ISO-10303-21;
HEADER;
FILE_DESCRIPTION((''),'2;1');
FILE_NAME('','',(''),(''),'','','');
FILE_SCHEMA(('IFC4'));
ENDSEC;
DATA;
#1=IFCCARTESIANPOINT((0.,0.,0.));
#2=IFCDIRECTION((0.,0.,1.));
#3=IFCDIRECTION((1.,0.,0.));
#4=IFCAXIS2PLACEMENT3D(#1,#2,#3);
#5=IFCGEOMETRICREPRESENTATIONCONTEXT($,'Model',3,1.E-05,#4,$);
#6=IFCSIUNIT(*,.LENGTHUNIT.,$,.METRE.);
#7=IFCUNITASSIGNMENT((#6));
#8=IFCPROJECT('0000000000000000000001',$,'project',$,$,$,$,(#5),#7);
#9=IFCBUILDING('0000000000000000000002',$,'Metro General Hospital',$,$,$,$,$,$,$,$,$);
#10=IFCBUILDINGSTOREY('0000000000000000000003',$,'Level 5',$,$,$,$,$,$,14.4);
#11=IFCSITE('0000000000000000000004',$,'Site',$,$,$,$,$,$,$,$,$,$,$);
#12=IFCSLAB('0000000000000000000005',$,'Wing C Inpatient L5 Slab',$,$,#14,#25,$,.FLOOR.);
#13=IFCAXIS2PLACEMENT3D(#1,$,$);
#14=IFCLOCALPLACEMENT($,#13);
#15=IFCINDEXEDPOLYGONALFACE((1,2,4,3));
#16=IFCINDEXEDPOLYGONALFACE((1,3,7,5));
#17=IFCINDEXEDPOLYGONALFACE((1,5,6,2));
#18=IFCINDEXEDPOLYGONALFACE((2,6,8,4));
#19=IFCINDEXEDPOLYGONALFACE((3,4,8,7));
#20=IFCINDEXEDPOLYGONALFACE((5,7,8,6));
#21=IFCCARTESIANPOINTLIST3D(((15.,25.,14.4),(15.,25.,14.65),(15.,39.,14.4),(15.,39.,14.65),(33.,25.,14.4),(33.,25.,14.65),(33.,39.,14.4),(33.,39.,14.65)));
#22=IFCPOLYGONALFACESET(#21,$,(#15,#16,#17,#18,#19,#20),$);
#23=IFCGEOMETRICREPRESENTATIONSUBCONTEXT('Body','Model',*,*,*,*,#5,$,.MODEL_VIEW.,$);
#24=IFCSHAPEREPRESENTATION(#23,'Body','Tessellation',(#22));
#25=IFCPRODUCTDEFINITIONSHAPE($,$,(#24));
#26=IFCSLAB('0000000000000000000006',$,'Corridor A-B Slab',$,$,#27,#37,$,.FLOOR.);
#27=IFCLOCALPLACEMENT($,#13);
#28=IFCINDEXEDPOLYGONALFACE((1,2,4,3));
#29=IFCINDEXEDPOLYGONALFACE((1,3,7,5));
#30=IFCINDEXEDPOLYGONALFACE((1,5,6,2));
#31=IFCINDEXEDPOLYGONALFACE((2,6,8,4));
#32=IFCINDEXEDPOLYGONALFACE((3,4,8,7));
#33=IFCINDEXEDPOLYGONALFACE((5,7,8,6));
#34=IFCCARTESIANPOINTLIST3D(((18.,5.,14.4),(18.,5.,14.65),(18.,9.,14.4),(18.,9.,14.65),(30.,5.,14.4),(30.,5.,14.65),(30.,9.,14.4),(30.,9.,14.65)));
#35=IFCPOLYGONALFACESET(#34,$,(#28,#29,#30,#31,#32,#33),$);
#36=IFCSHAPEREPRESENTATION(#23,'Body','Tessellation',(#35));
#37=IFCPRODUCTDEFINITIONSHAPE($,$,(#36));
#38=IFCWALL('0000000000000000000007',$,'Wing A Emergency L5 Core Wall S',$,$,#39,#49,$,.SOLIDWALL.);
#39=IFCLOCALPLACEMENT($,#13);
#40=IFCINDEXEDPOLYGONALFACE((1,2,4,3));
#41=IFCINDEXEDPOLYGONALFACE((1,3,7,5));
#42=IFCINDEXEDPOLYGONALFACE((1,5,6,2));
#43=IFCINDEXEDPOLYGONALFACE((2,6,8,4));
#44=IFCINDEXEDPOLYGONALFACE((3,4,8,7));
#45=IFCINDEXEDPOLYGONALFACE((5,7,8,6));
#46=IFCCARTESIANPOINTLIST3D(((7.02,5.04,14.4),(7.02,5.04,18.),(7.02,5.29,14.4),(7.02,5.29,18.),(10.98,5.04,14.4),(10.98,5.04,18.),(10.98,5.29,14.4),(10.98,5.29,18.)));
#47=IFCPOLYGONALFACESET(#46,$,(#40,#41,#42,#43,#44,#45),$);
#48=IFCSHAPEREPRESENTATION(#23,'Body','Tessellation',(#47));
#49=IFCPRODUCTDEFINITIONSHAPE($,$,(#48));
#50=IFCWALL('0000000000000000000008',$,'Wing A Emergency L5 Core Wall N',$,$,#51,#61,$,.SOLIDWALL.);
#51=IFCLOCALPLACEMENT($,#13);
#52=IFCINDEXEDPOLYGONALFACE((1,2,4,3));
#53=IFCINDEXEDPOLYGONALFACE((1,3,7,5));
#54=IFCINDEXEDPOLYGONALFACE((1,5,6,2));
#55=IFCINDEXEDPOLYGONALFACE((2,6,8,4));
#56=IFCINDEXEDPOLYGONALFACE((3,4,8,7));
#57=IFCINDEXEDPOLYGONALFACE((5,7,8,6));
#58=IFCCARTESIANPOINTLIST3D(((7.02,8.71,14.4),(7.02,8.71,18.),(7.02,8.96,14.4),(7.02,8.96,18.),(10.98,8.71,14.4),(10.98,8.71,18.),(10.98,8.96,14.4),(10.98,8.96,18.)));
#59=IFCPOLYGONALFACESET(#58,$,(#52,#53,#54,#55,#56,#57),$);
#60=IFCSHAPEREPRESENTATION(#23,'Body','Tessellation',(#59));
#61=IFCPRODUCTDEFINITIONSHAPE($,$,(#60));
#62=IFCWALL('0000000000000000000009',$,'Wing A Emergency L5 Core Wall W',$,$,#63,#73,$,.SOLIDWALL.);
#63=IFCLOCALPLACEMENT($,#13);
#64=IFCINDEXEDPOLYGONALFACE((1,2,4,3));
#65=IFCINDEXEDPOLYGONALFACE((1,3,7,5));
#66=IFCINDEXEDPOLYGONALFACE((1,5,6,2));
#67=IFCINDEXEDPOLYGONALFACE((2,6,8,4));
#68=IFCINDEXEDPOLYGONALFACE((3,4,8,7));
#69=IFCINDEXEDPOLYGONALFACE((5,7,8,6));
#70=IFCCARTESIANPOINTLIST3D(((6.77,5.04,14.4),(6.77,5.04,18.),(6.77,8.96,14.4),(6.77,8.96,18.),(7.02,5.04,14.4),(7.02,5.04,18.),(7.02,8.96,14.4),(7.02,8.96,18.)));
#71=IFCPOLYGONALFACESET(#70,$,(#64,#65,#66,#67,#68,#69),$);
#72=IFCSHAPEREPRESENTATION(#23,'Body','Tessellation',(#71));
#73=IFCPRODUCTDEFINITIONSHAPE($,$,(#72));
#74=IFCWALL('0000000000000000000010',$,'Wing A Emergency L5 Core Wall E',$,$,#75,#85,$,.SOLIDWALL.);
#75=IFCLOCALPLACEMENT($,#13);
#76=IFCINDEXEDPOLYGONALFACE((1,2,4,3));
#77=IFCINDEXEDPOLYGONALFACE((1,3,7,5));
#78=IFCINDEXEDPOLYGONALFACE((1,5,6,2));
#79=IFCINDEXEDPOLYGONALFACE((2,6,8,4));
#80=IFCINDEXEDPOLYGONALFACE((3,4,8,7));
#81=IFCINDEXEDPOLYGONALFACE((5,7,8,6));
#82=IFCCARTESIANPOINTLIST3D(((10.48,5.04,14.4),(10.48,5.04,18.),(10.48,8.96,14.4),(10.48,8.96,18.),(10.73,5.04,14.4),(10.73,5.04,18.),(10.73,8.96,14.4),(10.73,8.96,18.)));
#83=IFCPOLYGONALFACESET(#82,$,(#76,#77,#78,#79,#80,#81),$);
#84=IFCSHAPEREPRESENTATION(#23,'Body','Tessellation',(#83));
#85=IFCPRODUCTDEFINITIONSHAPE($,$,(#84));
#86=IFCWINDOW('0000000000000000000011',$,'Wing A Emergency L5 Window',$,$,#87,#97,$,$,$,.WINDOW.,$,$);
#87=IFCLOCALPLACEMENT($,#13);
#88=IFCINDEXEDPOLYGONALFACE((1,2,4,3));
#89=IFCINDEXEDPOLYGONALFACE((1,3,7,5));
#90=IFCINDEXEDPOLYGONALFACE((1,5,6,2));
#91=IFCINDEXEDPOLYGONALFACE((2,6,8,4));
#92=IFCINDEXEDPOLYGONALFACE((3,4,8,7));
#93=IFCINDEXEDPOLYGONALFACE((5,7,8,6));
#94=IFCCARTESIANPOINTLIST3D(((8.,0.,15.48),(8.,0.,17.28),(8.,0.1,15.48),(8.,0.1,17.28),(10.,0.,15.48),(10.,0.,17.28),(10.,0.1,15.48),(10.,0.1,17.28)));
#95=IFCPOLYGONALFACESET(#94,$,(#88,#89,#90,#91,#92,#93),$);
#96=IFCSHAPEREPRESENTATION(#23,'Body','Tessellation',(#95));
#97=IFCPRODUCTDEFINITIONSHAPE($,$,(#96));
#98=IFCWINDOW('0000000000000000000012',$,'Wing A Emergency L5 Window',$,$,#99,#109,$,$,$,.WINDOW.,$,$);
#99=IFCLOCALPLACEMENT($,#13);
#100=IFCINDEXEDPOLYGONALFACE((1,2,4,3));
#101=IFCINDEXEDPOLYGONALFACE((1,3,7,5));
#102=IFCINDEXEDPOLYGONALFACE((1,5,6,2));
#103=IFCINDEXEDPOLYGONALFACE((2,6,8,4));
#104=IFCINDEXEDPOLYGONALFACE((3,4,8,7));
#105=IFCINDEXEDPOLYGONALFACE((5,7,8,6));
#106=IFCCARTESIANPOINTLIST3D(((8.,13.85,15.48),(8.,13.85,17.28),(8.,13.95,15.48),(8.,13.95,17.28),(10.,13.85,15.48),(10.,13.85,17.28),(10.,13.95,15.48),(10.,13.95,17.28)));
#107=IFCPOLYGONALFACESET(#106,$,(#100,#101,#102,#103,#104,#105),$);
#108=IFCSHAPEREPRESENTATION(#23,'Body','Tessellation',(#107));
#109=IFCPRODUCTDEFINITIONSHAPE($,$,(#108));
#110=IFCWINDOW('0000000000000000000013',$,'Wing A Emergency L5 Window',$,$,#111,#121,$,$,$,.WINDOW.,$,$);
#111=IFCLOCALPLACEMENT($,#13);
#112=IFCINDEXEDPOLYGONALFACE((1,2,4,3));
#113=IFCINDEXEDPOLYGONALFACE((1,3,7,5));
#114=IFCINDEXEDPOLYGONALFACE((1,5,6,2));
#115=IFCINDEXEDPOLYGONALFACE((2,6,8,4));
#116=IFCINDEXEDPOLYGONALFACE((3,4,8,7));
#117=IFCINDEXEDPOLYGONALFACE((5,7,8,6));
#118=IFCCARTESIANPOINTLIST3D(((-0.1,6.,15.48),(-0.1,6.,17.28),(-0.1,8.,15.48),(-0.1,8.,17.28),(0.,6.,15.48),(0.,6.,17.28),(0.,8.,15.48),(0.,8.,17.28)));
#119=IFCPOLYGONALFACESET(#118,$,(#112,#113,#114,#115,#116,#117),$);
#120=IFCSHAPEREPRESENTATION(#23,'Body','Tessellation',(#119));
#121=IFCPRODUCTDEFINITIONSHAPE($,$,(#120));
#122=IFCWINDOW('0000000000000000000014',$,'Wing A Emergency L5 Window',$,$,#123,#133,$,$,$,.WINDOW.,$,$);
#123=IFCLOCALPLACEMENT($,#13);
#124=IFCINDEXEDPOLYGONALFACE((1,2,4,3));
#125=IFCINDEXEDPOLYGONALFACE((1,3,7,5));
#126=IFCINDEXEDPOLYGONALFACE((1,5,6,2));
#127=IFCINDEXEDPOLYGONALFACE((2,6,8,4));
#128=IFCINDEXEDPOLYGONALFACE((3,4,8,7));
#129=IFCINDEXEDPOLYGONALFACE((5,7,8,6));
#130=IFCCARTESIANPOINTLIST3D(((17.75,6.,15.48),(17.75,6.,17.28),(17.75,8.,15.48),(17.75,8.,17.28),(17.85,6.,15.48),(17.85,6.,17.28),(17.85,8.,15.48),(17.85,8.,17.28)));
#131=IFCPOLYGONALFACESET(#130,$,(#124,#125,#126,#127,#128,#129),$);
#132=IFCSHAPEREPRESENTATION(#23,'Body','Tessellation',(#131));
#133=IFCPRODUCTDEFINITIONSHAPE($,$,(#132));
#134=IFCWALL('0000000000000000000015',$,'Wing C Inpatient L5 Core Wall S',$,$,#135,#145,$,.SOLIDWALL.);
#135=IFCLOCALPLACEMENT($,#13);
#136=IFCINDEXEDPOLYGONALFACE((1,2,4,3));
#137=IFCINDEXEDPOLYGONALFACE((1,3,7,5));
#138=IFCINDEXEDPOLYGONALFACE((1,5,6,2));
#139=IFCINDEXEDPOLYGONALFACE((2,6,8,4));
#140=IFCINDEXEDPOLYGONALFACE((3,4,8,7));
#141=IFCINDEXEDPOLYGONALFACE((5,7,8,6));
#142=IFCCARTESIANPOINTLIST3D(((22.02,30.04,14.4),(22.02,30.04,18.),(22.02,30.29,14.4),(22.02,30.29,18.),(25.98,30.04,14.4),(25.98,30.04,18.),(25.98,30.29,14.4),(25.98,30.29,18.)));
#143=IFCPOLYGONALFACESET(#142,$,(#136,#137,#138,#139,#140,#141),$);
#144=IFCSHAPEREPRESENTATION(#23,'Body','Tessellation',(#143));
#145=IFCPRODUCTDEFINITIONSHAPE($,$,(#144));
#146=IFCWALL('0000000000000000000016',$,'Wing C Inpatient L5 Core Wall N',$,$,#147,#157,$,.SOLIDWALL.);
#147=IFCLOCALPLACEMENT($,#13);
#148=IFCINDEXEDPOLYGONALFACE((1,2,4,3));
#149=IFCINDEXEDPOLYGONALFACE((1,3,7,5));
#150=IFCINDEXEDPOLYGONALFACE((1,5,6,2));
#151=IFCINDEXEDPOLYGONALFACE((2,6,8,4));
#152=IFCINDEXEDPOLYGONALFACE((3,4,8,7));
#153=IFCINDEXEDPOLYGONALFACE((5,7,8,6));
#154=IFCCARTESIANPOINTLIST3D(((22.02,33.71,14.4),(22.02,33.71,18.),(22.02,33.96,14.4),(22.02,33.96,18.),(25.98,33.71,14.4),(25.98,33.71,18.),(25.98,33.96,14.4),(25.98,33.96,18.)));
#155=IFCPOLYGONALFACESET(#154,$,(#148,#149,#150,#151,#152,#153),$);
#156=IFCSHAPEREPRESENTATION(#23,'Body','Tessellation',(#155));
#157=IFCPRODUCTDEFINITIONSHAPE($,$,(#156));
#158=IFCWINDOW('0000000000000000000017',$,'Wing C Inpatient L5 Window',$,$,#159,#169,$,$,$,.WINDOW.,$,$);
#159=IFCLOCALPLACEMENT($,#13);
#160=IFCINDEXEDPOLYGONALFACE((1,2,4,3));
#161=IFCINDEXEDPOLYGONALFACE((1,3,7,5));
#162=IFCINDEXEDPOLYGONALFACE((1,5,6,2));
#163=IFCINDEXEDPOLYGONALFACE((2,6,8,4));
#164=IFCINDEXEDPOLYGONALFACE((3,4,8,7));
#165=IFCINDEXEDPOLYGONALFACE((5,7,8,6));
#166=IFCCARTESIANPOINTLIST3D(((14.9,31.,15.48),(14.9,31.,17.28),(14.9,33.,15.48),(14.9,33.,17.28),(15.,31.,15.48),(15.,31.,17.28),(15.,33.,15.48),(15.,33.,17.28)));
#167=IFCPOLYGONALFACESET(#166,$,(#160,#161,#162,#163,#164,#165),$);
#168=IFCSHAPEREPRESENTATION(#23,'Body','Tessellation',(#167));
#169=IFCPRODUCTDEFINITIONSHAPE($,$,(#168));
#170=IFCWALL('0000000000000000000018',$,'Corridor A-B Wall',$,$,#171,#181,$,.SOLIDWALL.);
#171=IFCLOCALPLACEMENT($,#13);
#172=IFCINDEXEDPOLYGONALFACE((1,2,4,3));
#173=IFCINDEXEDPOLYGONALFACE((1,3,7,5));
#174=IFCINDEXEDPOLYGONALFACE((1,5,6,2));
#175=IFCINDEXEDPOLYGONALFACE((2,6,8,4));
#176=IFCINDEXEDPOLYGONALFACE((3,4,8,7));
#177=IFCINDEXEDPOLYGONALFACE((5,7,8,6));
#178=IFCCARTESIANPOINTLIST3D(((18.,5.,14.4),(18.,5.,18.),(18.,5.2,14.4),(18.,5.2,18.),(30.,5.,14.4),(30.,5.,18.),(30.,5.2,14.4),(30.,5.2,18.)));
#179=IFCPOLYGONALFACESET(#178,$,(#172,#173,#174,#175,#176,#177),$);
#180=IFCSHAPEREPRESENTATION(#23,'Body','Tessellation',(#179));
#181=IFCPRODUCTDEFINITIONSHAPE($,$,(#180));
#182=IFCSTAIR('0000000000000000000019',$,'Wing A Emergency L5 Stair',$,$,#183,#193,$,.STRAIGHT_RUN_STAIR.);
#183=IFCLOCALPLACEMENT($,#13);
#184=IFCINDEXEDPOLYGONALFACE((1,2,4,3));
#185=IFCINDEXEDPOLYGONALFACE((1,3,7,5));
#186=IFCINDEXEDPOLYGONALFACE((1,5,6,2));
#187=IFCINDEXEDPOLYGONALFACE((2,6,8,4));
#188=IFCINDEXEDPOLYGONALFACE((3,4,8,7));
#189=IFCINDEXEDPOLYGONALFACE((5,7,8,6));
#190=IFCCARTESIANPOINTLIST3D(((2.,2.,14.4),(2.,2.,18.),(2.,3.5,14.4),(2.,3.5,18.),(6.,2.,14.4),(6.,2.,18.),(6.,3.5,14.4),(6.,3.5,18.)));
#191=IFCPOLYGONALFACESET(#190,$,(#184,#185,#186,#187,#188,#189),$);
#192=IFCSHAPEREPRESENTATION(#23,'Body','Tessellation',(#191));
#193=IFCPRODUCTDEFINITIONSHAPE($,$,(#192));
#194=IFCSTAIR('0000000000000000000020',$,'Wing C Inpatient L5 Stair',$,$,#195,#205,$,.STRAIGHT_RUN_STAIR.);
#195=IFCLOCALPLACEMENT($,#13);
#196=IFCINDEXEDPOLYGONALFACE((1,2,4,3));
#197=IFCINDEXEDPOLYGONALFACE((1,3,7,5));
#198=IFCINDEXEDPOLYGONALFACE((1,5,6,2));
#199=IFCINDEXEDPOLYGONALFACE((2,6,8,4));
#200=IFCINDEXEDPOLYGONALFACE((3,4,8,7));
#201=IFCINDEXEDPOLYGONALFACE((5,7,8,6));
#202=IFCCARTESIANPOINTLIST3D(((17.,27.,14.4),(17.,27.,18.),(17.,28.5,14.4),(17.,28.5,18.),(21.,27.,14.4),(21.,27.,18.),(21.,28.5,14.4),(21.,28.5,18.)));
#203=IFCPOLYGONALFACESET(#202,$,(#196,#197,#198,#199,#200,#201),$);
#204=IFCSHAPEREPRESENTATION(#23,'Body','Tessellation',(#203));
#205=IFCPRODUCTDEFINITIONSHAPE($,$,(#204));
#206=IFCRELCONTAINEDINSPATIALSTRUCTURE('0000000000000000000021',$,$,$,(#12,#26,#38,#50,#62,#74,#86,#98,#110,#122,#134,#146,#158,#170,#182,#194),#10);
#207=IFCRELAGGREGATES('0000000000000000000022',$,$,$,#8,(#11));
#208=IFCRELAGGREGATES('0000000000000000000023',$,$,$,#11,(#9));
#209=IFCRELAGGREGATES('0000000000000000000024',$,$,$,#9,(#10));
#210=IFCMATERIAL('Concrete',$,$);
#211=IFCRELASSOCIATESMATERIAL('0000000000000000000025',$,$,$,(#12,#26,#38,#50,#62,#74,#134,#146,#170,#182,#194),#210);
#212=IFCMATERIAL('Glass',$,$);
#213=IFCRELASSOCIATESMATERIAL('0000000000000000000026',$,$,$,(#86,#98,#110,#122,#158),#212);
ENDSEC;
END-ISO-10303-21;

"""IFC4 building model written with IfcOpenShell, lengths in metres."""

from ifc_helpers import new_model, si_unit, frame, origin_with_axes, place, context, subcontext, project, spatial, line, indexed_curve, outline, extrude, material, element, save


model = new_model("IFC4")

# Units and contexts
model_context = context("Model", 3, precision=1e-05, world=origin_with_axes())
body_context = subcontext(model_context, "Body", "Model", "MODEL_VIEW")
ifc_project = project(units=[si_unit("LENGTHUNIT", "METRE")], contexts=[model_context])

# Site, building, storey
site = spatial("IfcSite", under=ifc_project, Name="Site")
building = spatial("IfcBuilding", under=site, Name="Metro General Hospital")
storey = spatial("IfcBuildingStorey", under=building, Name="Level 5", Elevation=14.4)

# Slabs
ifc_material_1 = material(Name="Concrete")
for number, where, z_axis, x_axis, name in (
    (1, (15.0, 25.0, 14.4), (0.0, 0.0, 1.0), (1.0, 0.0, 0.0), "Wing C Inpatient L5 Slab"),
):
    element("IfcSlab", number, at=place(None, frame(where, z_axis=z_axis, x_axis=x_axis)), inside=storey, material=ifc_material_1, Name=name, PredefinedType="FLOOR", context=body_context, shape_type="SweptSolid", body=[
        extrude(outline(indexed_curve([(0.0, 0.0), (18.0, 0.0), (18.0, 14.0), (0.0, 14.0)], segments=[line(1, 2, 3, 4, 1)])), origin_with_axes(), (0.0, 0.0, 1.0), 0.25),
    ])
slab_placement = place(None, frame((18.0, 5.0, 14.4), z_axis=(0.0, 0.0, 1.0), x_axis=(1.0, 0.0, 0.0)))
element("IfcSlab", 2, at=slab_placement, inside=storey, material=ifc_material_1, Name="Corridor A-B Slab", PredefinedType="FLOOR", context=body_context, shape_type="SweptSolid", body=[
    extrude(outline(indexed_curve([(0.0, 0.0), (12.0, 0.0), (12.0, 4.0), (0.0, 4.0)], segments=[line(1, 2, 3, 4, 1)])), origin_with_axes(), (0.0, 0.0, 1.0), 0.25),
])

# Walls
for number, where, z_axis, x_axis, name in (
    (3, (7.02, 5.04, 14.4), (0.0, 0.0, 1.0), (1.0, 0.0, 0.0), "Wing A Emergency L5 Core Wall S"),
    (4, (7.02, 8.71, 14.4), (0.0, 0.0, 1.0), (1.0, 0.0, 0.0), "Wing A Emergency L5 Core Wall N"),
):
    element("IfcWall", number, at=place(None, frame(where, z_axis=z_axis, x_axis=x_axis)), inside=storey, material=ifc_material_1, Name=name, PredefinedType="SOLIDWALL", context=body_context, shape_type="SweptSolid", body=[
        extrude(outline(indexed_curve([(0.0, 0.0), (3.96, 0.0), (3.96, 0.25), (0.0, 0.25)], segments=[line(1, 2, 3, 4, 1)])), origin_with_axes(), (0.0, 0.0, 1.0), 3.6),
    ])
for number, where, z_axis, x_axis, name in (
    (5, (7.02, 5.04, 14.4), (0.0, 0.0, 1.0), (0.0, 1.0, 0.0), "Wing A Emergency L5 Core Wall W"),
    (6, (10.73, 5.04, 14.4), (0.0, 0.0, 1.0), (0.0, 1.0, 0.0), "Wing A Emergency L5 Core Wall E"),
):
    element("IfcWall", number, at=place(None, frame(where, z_axis=z_axis, x_axis=x_axis)), inside=storey, material=ifc_material_1, Name=name, PredefinedType="SOLIDWALL", context=body_context, shape_type="SweptSolid", body=[
        extrude(outline(indexed_curve([(0.0, 0.0), (3.92, 0.0), (3.92, 0.25), (0.0, 0.25)], segments=[line(1, 2, 3, 4, 1)])), origin_with_axes(), (0.0, 0.0, 1.0), 3.6),
    ])

# Windows
ifc_material_2 = material(Name="Glass")
for number, where, z_axis, x_axis, name in (
    (7, (8.0, 0.0, 15.48), (0.0, 0.0, 1.0), (1.0, 0.0, 0.0), "Wing A Emergency L5 Window"),
    (8, (8.0, 13.85, 15.48), (0.0, 0.0, 1.0), (1.0, 0.0, 0.0), "Wing A Emergency L5 Window"),
    (9, (0.0, 6.0, 15.48), (0.0, 0.0, 1.0), (0.0, 1.0, 0.0), "Wing A Emergency L5 Window"),
    (10, (17.85, 6.0, 15.48), (0.0, 0.0, 1.0), (0.0, 1.0, 0.0), "Wing A Emergency L5 Window"),
):
    element("IfcWindow", number, at=place(None, frame(where, z_axis=z_axis, x_axis=x_axis)), inside=storey, material=ifc_material_2, Name=name, PredefinedType="WINDOW", context=body_context, shape_type="SweptSolid", body=[
        extrude(outline(indexed_curve([(0.0, 0.0), (2.0, 0.0), (2.0, 0.1), (0.0, 0.1)], segments=[line(1, 2, 3, 4, 1)])), origin_with_axes(), (0.0, 0.0, 1.0), 1.8),
    ])

# Walls
for number, where, z_axis, x_axis, name in (
    (11, (22.02, 30.04, 14.4), (0.0, 0.0, 1.0), (1.0, 0.0, 0.0), "Wing C Inpatient L5 Core Wall S"),
    (12, (22.02, 33.71, 14.4), (0.0, 0.0, 1.0), (1.0, 0.0, 0.0), "Wing C Inpatient L5 Core Wall N"),
):
    element("IfcWall", number, at=place(None, frame(where, z_axis=z_axis, x_axis=x_axis)), inside=storey, material=ifc_material_1, Name=name, PredefinedType="SOLIDWALL", context=body_context, shape_type="SweptSolid", body=[
        extrude(outline(indexed_curve([(0.0, 0.0), (3.96, 0.0), (3.96, 0.25), (0.0, 0.25)], segments=[line(1, 2, 3, 4, 1)])), origin_with_axes(), (0.0, 0.0, 1.0), 3.6),
    ])

# Window
window_placement = place(None, frame((15.0, 31.0, 15.48), z_axis=(0.0, 0.0, 1.0), x_axis=(0.0, 1.0, 0.0)))
element("IfcWindow", 13, at=window_placement, inside=storey, material=ifc_material_2, Name="Wing C Inpatient L5 Window", PredefinedType="WINDOW", context=body_context, shape_type="SweptSolid", body=[
    extrude(outline(indexed_curve([(0.0, 0.0), (2.0, 0.0), (2.0, 0.1), (0.0, 0.1)], segments=[line(1, 2, 3, 4, 1)])), origin_with_axes(), (0.0, 0.0, 1.0), 1.8),
])

# Wall
wall_placement = place(None, frame((18.0, 5.0, 14.4), z_axis=(0.0, 0.0, 1.0), x_axis=(1.0, 0.0, 0.0)))
element("IfcWall", 14, at=wall_placement, inside=storey, material=ifc_material_1, Name="Corridor A-B Wall", PredefinedType="SOLIDWALL", context=body_context, shape_type="SweptSolid", body=[
    extrude(outline(indexed_curve([(0.0, 0.0), (12.0, 0.0), (12.0, 0.2), (0.0, 0.2)], segments=[line(1, 2, 3, 4, 1)])), origin_with_axes(), (0.0, 0.0, 1.0), 3.6),
])

# Stairs
for number, where, z_axis, x_axis, name in (
    (15, (2.0, 2.0, 14.4), (0.0, 0.0, 1.0), (1.0, 0.0, 0.0), "Wing A Emergency L5 Stair"),
    (16, (17.0, 27.0, 14.4), (0.0, 0.0, 1.0), (1.0, 0.0, 0.0), "Wing C Inpatient L5 Stair"),
):
    element("IfcStair", number, at=place(None, frame(where, z_axis=z_axis, x_axis=x_axis)), inside=storey, material=ifc_material_1, Name=name, PredefinedType="STRAIGHT_RUN_STAIR", context=body_context, shape_type="SweptSolid", body=[
        extrude(outline(indexed_curve([(0.0, 0.0), (4.0, 0.0), (4.0, 1.5), (0.0, 1.5)], segments=[line(1, 2, 3, 4, 1)])), origin_with_axes(), (0.0, 0.0, 1.0), 3.6),
    ])

save(model, "model.ifc")
